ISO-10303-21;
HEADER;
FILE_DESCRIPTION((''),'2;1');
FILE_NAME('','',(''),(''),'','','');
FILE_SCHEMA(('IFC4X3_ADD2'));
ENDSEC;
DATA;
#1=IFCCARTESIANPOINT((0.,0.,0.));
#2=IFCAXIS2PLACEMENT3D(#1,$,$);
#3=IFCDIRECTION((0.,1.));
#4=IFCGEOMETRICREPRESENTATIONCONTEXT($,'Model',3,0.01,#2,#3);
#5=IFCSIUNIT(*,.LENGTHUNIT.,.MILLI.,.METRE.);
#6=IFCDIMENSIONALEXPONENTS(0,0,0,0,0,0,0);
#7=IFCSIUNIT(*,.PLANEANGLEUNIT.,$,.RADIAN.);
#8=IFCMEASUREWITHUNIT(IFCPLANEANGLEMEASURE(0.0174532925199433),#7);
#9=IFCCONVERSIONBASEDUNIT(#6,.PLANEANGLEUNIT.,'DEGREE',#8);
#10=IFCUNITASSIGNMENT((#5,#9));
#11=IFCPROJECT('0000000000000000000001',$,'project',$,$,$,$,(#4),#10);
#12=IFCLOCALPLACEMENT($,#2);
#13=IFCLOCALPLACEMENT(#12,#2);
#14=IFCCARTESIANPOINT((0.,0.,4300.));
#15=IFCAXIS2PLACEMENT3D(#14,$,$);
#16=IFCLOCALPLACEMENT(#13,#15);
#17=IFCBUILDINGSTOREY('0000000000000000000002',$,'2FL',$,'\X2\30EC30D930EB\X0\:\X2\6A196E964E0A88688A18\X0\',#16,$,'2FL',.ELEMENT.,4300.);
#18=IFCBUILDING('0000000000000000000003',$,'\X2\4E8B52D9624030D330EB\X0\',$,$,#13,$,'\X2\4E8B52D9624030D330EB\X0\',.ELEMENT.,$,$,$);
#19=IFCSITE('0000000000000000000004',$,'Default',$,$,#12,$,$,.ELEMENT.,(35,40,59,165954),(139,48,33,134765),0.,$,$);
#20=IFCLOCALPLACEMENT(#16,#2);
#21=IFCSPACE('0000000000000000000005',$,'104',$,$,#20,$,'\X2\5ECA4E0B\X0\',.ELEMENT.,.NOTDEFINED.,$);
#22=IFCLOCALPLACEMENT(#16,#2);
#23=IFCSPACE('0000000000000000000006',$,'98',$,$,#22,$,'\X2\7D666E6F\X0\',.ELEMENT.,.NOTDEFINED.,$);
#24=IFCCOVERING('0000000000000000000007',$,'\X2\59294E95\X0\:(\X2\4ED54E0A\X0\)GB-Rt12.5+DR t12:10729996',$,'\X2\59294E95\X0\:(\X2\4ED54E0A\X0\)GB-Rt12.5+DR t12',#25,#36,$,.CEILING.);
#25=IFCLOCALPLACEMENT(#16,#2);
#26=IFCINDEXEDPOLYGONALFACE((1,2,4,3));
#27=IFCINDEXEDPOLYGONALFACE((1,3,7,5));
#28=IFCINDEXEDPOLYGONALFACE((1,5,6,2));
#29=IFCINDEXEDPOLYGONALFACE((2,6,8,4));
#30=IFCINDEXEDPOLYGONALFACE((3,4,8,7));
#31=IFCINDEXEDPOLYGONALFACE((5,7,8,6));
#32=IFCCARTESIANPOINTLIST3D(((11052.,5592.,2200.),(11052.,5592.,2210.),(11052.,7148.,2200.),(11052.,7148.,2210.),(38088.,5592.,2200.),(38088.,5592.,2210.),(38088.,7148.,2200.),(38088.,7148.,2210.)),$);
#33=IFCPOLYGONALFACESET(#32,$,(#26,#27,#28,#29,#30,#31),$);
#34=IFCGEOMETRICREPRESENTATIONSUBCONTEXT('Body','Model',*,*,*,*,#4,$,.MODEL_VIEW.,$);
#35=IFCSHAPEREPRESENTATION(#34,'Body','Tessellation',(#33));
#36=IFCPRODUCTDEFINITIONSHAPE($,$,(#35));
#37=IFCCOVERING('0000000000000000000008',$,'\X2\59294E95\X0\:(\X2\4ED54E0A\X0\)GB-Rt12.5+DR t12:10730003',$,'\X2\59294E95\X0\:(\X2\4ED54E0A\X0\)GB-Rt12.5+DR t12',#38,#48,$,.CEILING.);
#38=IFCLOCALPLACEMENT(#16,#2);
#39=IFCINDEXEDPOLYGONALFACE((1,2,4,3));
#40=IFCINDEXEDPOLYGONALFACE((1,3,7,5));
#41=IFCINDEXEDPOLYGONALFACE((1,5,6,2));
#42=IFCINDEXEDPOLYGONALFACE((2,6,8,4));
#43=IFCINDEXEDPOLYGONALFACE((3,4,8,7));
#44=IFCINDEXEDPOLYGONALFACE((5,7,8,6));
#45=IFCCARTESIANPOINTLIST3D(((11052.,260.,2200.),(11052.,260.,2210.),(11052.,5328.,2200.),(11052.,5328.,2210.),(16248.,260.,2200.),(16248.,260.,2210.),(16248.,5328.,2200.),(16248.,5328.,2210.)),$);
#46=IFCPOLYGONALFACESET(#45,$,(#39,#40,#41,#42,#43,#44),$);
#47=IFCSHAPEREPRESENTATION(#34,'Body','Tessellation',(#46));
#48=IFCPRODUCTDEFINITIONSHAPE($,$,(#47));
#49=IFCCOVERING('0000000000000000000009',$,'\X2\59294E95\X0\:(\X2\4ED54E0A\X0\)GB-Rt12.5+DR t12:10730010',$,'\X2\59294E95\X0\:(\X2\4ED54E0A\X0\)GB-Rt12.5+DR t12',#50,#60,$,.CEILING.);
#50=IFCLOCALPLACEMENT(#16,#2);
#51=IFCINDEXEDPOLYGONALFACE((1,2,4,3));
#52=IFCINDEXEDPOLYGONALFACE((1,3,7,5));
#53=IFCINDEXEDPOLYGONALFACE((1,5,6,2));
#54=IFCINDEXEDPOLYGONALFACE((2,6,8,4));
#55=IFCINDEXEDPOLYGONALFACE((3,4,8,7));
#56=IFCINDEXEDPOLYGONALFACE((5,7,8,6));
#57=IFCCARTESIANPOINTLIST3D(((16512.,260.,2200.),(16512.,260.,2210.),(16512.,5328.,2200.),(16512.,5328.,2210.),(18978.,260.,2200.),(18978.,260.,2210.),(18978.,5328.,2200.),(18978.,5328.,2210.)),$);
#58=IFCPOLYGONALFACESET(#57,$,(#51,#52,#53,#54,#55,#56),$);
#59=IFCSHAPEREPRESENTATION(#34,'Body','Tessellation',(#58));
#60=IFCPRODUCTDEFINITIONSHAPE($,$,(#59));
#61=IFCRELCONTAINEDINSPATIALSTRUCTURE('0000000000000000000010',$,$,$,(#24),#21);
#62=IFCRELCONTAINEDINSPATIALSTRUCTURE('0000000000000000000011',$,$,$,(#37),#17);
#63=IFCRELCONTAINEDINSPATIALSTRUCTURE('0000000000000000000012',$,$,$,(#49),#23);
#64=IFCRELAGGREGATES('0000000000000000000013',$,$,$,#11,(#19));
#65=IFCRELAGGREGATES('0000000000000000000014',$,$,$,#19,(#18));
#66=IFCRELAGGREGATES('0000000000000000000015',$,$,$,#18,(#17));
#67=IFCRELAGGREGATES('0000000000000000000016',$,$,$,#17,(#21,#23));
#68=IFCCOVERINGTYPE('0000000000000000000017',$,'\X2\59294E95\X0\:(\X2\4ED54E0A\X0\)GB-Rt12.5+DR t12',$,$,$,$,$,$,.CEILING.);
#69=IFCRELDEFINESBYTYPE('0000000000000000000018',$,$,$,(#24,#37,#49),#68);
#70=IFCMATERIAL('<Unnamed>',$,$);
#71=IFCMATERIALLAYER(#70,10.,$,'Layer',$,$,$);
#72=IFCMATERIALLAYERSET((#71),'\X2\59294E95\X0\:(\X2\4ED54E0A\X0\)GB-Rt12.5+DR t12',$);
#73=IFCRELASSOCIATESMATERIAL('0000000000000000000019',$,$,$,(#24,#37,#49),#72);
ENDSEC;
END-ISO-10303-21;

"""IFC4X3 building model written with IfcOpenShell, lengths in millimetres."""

from ifc_helpers import new_model, entity, si_unit, converted_unit, direction, frame, frame_2d, origin, origin_2d_with_axis, place, context, subcontext, project, spatial, rectangle, extrude, material, layer, layer_set, layer_usage, type_object, element, save


model = new_model("IFC4X3")

# Units and contexts
model_context = context("Model", 3, precision=0.01, world=origin(), true_north=direction((0.0, 1.0)))
body_context = subcontext(model_context, "Body", "Model", "MODEL_VIEW")
ifc_project = project(units=[si_unit("LENGTHUNIT", "METRE", prefix="MILLI"), converted_unit("PLANEANGLEUNIT", "DEGREE", entity("IfcPlaneAngleMeasure", 0.0174532925199433), si_unit("PLANEANGLEUNIT", "RADIAN"), dimensions=[0, 0, 0, 0, 0, 0, 0])], contexts=[model_context])

# Site, building, storey
site_placement = place(None, origin())
site = spatial("IfcSite", under=ifc_project, at=site_placement, Name="Default", CompositionType="ELEMENT", RefLatitude=(35, 40, 59, 165954), RefLongitude=(139, 48, 33, 134765), RefElevation=0.0)
building_placement = place(site_placement, origin())
building = spatial("IfcBuilding", under=site, at=building_placement, Name="事務所ビル", LongName="事務所ビル", CompositionType="ELEMENT")
storey_placement = place(building_placement, frame((0.0, 0.0, 4300.0)))
storey = spatial("IfcBuildingStorey", under=building, at=storey_placement, Name="2FL", ObjectType="レベル:標準上表記", LongName="2FL", CompositionType="ELEMENT", Elevation=4300.0)

# Shared definitions
ifc_material_1 = material(Name="<Unnamed>")

# Shared definitions
ifc_layer_1 = layer(ifc_material_1, 10.0, Name="Layer")
ifc_layer_set_1 = layer_set([ifc_layer_1], Name="天井:(仕上)GB-Rt12.5+DR t12")
covering_type = type_object("IfcCoveringType", Name="天井:(仕上)GB-Rt12.5+DR t12", PredefinedType="CEILING")

# Shared definitions
space_1_placement = place(storey_placement, origin())
space_1 = spatial("IfcSpace", under=storey, at=space_1_placement, Name="104", LongName="廊下", CompositionType="ELEMENT", PredefinedType="NOTDEFINED")

# Coverings
ifc_layer_usage_1 = layer_usage(ifc_layer_set_1, "AXIS3", "NEGATIVE", 0.0)
covering_1_placement = place(space_1_placement, frame((11052.0, 5592.0, 2200.0)))
element("IfcCovering", 1, at=covering_1_placement, inside=space_1, type_object=covering_type, material=ifc_layer_usage_1, Name="天井:(仕上)GB-Rt12.5+DR t12:10729996", ObjectType="天井:(仕上)GB-Rt12.5+DR t12", PredefinedType="CEILING", context=body_context, shape_type="SweptSolid", body=[
    extrude(rectangle(XDim=1556.0, YDim=27036.0, at=frame_2d((0.0, 0.0), x_axis=(1.0, 0.0))), frame((13518.0, 778.0, 0.0), z_axis=(0.0, 0.0, 1.0), x_axis=(0.0, -1.0, 0.0)), (0.0, 0.0, 1.0), 10.0),
])
ifc_layer_usage_2 = layer_usage(ifc_layer_set_1, "AXIS3", "NEGATIVE", 0.0)
covering_2_placement = place(storey_placement, frame((11052.0, 260.0, 2200.0)))
element("IfcCovering", 2, at=covering_2_placement, inside=storey, type_object=covering_type, material=ifc_layer_usage_2, Name="天井:(仕上)GB-Rt12.5+DR t12:10730003", ObjectType="天井:(仕上)GB-Rt12.5+DR t12", PredefinedType="CEILING", context=body_context, shape_type="SweptSolid", body=[
    extrude(rectangle(XDim=5196.0, YDim=5068.0, at=origin_2d_with_axis()), frame((2598.0, 2534.0, 0.0), z_axis=(0.0, 0.0, 1.0), x_axis=(-1.0, 0.0, 0.0)), (0.0, 0.0, 1.0), 10.0),
])

# Shared definitions
space_2_placement = place(storey_placement, origin())
space_2 = spatial("IfcSpace", under=storey, at=space_2_placement, Name="98", LongName="給湯", CompositionType="ELEMENT", PredefinedType="NOTDEFINED")

# Covering
ifc_layer_usage_3 = layer_usage(ifc_layer_set_1, "AXIS3", "NEGATIVE", 0.0)
covering_3_placement = place(space_2_placement, frame((16512.0, 260.0, 2200.0)))
element("IfcCovering", 3, at=covering_3_placement, inside=space_2, type_object=covering_type, material=ifc_layer_usage_3, Name="天井:(仕上)GB-Rt12.5+DR t12:10730010", ObjectType="天井:(仕上)GB-Rt12.5+DR t12", PredefinedType="CEILING", context=body_context, shape_type="SweptSolid", body=[
    extrude(rectangle(XDim=2466.0, YDim=5068.0, at=frame_2d((0.0, 0.0), x_axis=(1.0, 0.0))), frame((1233.0, 2534.0, 0.0), z_axis=(0.0, 0.0, 1.0), x_axis=(-1.0, 0.0, 0.0)), (0.0, 0.0, 1.0), 10.0),
])

save(model, "model.ifc")
